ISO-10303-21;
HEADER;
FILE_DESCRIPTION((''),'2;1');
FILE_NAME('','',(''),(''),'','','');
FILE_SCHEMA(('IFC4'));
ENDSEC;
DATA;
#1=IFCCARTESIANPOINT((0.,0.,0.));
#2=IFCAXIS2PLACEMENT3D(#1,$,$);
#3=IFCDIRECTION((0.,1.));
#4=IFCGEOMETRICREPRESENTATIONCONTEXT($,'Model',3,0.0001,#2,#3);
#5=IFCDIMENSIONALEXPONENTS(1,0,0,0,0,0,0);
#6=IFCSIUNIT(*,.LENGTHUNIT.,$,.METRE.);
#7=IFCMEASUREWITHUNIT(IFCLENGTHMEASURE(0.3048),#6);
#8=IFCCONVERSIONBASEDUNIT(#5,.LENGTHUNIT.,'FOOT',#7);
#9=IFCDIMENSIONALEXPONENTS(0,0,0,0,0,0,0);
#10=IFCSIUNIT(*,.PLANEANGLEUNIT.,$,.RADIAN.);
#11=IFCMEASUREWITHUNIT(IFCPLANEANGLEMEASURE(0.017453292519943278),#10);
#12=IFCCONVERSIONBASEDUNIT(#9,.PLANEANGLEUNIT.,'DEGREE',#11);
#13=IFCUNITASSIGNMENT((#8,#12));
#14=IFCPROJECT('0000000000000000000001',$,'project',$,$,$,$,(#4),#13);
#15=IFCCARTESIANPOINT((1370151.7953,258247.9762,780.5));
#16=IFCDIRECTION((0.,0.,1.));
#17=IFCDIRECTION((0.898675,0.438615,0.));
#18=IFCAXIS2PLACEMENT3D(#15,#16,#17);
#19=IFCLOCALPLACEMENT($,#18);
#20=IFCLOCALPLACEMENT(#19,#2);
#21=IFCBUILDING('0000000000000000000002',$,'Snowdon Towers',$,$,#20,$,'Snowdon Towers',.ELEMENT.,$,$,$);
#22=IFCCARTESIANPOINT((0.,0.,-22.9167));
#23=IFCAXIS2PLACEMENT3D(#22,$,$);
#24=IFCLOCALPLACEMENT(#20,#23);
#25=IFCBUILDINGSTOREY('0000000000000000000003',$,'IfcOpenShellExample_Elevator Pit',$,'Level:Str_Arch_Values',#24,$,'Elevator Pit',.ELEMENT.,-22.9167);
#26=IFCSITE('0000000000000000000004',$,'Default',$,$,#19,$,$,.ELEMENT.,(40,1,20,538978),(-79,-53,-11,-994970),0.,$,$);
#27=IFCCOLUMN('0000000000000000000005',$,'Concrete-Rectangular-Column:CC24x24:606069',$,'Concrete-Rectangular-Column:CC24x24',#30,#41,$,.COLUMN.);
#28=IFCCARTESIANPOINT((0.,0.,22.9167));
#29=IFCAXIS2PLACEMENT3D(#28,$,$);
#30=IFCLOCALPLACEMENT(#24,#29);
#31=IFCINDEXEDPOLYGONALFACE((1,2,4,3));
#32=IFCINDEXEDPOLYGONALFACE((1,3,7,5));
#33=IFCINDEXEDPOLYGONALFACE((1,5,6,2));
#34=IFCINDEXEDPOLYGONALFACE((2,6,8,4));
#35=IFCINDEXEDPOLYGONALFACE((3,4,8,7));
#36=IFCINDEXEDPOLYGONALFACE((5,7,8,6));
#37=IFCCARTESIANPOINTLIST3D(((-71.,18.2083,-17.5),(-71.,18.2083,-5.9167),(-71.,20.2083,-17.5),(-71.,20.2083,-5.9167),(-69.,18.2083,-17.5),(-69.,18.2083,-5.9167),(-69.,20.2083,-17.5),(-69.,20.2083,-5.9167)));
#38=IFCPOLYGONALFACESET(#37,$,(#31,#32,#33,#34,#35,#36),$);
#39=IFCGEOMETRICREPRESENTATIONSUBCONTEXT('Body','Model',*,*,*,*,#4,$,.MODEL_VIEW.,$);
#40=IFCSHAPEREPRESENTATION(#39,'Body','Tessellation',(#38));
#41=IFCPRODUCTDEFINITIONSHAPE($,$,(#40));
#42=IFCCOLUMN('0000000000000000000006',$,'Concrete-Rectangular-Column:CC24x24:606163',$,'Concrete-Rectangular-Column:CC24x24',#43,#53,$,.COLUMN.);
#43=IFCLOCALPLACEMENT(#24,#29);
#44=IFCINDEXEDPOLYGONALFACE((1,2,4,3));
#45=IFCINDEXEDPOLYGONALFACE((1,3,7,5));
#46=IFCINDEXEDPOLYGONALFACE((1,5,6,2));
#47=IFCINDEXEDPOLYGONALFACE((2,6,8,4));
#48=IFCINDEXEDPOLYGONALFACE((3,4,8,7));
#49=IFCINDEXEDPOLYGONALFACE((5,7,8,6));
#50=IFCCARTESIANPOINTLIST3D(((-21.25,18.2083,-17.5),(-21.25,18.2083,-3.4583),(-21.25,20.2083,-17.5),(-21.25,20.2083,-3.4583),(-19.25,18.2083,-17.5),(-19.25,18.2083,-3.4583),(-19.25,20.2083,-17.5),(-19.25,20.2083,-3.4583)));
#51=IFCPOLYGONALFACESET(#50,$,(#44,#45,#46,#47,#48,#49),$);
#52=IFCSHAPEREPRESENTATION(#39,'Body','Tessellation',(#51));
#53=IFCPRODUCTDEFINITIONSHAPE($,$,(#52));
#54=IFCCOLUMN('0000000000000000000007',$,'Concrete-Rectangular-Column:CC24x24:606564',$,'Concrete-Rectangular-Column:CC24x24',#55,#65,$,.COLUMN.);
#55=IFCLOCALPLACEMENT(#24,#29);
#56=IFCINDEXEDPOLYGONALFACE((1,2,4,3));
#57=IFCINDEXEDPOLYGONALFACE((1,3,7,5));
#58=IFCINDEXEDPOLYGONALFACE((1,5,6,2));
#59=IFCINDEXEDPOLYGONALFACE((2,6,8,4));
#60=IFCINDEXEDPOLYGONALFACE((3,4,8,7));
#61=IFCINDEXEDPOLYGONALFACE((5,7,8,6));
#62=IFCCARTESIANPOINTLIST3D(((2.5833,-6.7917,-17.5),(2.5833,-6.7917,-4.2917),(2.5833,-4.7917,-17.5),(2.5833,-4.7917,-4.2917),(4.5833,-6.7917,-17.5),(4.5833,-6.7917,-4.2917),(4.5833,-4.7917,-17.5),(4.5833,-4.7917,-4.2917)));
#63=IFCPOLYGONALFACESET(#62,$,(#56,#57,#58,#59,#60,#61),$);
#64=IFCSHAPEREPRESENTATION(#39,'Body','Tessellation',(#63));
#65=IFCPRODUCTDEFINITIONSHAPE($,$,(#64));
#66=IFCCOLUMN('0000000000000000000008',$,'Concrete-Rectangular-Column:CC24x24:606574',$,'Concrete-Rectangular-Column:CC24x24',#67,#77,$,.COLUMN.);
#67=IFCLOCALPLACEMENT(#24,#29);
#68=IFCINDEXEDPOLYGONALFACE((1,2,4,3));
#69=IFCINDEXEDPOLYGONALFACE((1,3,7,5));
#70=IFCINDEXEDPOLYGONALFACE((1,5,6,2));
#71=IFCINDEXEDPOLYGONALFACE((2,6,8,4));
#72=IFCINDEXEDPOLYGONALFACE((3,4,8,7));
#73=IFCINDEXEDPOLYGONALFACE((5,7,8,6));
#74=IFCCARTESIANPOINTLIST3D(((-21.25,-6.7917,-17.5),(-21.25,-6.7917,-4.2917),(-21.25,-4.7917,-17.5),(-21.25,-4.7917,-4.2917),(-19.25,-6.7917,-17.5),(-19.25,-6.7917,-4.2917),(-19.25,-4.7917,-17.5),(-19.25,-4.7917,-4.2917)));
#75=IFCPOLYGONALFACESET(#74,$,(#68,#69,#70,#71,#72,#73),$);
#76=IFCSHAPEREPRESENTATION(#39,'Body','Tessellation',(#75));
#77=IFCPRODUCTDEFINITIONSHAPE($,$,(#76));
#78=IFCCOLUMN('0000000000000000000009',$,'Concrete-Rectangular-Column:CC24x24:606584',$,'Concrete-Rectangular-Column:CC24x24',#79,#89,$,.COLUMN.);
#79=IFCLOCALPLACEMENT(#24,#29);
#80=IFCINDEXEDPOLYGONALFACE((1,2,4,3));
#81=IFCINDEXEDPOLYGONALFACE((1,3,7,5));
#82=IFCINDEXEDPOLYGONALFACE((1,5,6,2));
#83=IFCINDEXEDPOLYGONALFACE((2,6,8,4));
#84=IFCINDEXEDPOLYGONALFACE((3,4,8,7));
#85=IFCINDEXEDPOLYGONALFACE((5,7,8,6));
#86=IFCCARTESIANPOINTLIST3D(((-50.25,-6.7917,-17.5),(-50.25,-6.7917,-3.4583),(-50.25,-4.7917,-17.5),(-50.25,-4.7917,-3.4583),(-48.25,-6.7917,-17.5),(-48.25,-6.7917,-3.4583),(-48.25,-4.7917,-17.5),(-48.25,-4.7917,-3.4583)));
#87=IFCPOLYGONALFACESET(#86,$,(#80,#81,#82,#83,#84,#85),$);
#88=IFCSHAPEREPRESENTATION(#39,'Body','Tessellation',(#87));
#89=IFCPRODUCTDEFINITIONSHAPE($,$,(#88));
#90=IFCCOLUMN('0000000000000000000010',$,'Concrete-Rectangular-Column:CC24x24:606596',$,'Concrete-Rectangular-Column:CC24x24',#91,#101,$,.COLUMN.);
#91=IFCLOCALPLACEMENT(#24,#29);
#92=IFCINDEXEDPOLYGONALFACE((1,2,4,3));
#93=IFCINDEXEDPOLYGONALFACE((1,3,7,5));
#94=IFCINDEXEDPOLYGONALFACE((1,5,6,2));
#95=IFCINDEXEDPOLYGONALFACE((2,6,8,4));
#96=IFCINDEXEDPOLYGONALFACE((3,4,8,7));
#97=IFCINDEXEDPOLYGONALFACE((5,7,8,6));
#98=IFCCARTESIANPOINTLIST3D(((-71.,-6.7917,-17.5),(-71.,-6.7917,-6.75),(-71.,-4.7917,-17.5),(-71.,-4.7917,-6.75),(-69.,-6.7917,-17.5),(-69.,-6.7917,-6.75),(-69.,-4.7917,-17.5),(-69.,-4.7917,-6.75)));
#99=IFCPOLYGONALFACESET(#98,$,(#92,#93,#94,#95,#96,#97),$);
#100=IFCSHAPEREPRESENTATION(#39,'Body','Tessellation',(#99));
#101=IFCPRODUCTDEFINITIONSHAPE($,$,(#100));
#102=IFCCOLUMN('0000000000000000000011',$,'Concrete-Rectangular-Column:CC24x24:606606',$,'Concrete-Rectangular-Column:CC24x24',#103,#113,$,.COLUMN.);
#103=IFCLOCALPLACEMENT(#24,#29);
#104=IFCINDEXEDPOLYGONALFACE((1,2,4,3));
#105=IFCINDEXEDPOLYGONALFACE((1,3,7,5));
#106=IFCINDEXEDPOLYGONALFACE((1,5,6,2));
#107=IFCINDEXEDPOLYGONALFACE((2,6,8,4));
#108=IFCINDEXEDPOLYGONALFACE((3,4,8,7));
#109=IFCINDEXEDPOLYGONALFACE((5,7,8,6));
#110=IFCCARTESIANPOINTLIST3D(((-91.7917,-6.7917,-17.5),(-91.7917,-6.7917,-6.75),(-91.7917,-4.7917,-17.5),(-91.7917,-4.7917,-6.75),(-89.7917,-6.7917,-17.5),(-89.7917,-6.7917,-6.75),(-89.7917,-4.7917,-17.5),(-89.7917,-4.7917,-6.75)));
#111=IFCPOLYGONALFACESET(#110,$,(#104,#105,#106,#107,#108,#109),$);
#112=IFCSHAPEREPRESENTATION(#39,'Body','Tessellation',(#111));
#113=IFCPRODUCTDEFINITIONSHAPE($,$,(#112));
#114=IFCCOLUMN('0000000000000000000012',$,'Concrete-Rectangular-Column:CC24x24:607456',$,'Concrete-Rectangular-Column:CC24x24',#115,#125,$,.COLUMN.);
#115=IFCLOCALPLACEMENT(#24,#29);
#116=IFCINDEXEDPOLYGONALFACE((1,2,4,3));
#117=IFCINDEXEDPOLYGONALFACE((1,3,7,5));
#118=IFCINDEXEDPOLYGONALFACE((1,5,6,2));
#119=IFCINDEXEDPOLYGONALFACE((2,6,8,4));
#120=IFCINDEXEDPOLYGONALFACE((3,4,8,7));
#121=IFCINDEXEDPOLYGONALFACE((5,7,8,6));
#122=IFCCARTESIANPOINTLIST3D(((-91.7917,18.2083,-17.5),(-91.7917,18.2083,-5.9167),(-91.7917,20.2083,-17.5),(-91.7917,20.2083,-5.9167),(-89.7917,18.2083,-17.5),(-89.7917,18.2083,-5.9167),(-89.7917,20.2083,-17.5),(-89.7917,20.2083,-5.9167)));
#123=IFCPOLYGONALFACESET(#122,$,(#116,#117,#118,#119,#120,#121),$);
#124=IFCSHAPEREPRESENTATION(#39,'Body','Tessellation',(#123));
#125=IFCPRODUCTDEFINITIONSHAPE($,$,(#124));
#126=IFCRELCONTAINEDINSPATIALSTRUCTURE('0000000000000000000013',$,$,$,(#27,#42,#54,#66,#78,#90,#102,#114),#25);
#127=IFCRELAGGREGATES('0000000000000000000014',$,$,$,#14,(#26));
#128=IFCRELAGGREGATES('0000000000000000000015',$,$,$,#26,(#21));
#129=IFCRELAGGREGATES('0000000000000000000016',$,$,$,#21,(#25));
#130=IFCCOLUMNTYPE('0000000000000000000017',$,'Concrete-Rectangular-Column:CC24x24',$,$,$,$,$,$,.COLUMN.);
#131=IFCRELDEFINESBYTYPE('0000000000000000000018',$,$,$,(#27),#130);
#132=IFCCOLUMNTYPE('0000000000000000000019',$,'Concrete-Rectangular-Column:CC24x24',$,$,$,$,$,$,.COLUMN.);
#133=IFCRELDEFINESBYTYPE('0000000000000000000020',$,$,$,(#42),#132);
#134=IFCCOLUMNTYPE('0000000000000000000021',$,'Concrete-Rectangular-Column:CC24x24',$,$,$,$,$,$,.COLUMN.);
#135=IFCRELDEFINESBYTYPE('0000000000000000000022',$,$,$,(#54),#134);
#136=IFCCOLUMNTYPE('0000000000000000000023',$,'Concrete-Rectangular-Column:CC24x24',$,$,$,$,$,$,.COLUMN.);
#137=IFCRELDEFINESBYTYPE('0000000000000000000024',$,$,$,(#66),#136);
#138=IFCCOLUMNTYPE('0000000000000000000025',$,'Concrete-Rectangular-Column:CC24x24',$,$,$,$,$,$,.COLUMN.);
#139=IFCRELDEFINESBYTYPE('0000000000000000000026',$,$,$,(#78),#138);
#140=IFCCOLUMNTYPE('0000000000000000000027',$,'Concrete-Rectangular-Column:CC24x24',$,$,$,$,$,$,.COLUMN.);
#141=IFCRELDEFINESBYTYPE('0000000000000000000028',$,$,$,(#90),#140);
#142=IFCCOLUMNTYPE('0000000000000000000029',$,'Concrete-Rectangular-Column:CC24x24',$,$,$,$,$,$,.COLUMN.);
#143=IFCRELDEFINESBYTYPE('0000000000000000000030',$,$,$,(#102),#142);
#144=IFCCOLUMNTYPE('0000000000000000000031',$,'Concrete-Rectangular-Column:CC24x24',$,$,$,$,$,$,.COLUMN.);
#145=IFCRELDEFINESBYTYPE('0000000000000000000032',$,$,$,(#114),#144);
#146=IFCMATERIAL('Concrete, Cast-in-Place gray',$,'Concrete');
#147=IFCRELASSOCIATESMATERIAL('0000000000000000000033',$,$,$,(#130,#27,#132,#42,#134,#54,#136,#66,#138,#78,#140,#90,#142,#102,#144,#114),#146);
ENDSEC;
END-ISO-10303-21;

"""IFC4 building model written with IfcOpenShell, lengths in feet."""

from ifc_helpers import new_model, entity, si_unit, converted_unit, direction, frame, origin, place, context, subcontext, project, spatial, indexed_curve, outline, extrude, source, transform, mapped, material, type_object, type_shapes, element, save


model = new_model("IFC4")

# Units and contexts
model_context = context("Model", 3, precision=0.0001, world=origin(), true_north=direction((0.0, 1.0)))
body_context = subcontext(model_context, "Body", "Model", "MODEL_VIEW")
ifc_project = project(units=[converted_unit("LENGTHUNIT", "FOOT", entity("IfcLengthMeasure", 0.3048), si_unit("LENGTHUNIT", "METRE"), dimensions=[1, 0, 0, 0, 0, 0, 0]), converted_unit("PLANEANGLEUNIT", "DEGREE", entity("IfcPlaneAngleMeasure", 0.017453292519943278), si_unit("PLANEANGLEUNIT", "RADIAN"), dimensions=[0, 0, 0, 0, 0, 0, 0])], contexts=[model_context])

# Site, building, storey
site_placement = place(None, frame((1370151.7953, 258247.9762, 780.5), z_axis=(0.0, 0.0, 1.0), x_axis=(0.898675, 0.438615, 0.0)))
site = spatial("IfcSite", under=ifc_project, at=site_placement, Name="Default", CompositionType="ELEMENT", RefLatitude=(40, 1, 20, 538978), RefLongitude=(-79, -53, -11, -994970), RefElevation=0.0)
building_placement = place(site_placement, origin())
building = spatial("IfcBuilding", under=site, at=building_placement, Name="Snowdon Towers", LongName="Snowdon Towers", CompositionType="ELEMENT")
storey_placement = place(building_placement, frame((0.0, 0.0, -22.9167)))
storey = spatial("IfcBuildingStorey", under=building, at=storey_placement, Name="IfcOpenShellExample_Elevator Pit", ObjectType="Level:Str_Arch_Values", LongName="Elevator Pit", CompositionType="ELEMENT", Elevation=-22.9167)

# Shared definitions
ifc_material = material(Name="Concrete, Cast-in-Place gray", Category="Concrete")

# Columns
column_type_1 = type_object("IfcColumnType", Name="Concrete-Rectangular-Column:CC24x24", PredefinedType="COLUMN", material=ifc_material)
shared_shape_1 = source(origin(), body_context, "Body", "SweptSolid", [
    extrude(outline(indexed_curve([(-1.0, -1.0), (1.0, -1.0), (1.0, 1.0), (-1.0, 1.0), (-1.0, -1.0)], self_intersect=False)), frame((-70.0, 19.2083, -17.5), z_axis=(0.0, 0.0, 1.0), x_axis=(-1.0, 0.0, 0.0)), (0.0, 0.0, 1.0), 11.5833),
])
type_shapes(column_type_1, [shared_shape_1])
column_1_placement = place(storey_placement, frame((0.0, 0.0, 22.9167)))
element("IfcColumn", 1, at=column_1_placement, inside=storey, type_object=column_type_1, material=ifc_material, Name="Concrete-Rectangular-Column:CC24x24:606069", ObjectType="Concrete-Rectangular-Column:CC24x24", PredefinedType="COLUMN", context=body_context, shape_type="MappedRepresentation", body=[
    mapped(shared_shape_1, transform((0.0, 0.0, 0.0), scale=1.0)),
])
column_type_2 = type_object("IfcColumnType", Name="Concrete-Rectangular-Column:CC24x24", PredefinedType="COLUMN", material=ifc_material)
shared_shape_2 = source(origin(), body_context, "Body", "SweptSolid", [
    extrude(outline(indexed_curve([(-1.0, -1.0), (1.0, -1.0), (1.0, 1.0), (-1.0, 1.0), (-1.0, -1.0)], self_intersect=False)), frame((-20.25, 19.2083, -17.5), z_axis=(0.0, 0.0, 1.0), x_axis=(-1.0, 0.0, 0.0)), (0.0, 0.0, 1.0), 14.0417),
])
type_shapes(column_type_2, [shared_shape_2])
column_2_placement = place(storey_placement, frame((0.0, 0.0, 22.9167)))
element("IfcColumn", 2, at=column_2_placement, inside=storey, type_object=column_type_2, material=ifc_material, Name="Concrete-Rectangular-Column:CC24x24:606163", ObjectType="Concrete-Rectangular-Column:CC24x24", PredefinedType="COLUMN", context=body_context, shape_type="MappedRepresentation", body=[
    mapped(shared_shape_2, transform((0.0, 0.0, 0.0), scale=1.0)),
])
column_type_3 = type_object("IfcColumnType", Name="Concrete-Rectangular-Column:CC24x24", PredefinedType="COLUMN", material=ifc_material)
shared_shape_3 = source(origin(), body_context, "Body", "SweptSolid", [
    extrude(outline(indexed_curve([(-1.0, -1.0), (1.0, -1.0), (1.0, 1.0), (-1.0, 1.0), (-1.0, -1.0)], self_intersect=False)), frame((3.5833, -5.7917, -17.5), z_axis=(0.0, 0.0, 1.0), x_axis=(-1.0, 0.0, 0.0)), (0.0, 0.0, 1.0), 13.2083),
])
type_shapes(column_type_3, [shared_shape_3])
column_3_placement = place(storey_placement, frame((0.0, 0.0, 22.9167)))
element("IfcColumn", 3, at=column_3_placement, inside=storey, type_object=column_type_3, material=ifc_material, Name="Concrete-Rectangular-Column:CC24x24:606564", ObjectType="Concrete-Rectangular-Column:CC24x24", PredefinedType="COLUMN", context=body_context, shape_type="MappedRepresentation", body=[
    mapped(shared_shape_3, transform((0.0, 0.0, 0.0), scale=1.0)),
])
column_type_4 = type_object("IfcColumnType", Name="Concrete-Rectangular-Column:CC24x24", PredefinedType="COLUMN", material=ifc_material)
shared_shape_4 = source(origin(), body_context, "Body", "SweptSolid", [
    extrude(outline(indexed_curve([(-1.0, -1.0), (1.0, -1.0), (1.0, 1.0), (-1.0, 1.0), (-1.0, -1.0)], self_intersect=False)), frame((-20.25, -5.7917, -17.5), z_axis=(0.0, 0.0, 1.0), x_axis=(-1.0, 0.0, 0.0)), (0.0, 0.0, 1.0), 13.2083),
])
type_shapes(column_type_4, [shared_shape_4])
column_4_placement = place(storey_placement, frame((0.0, 0.0, 22.9167)))
element("IfcColumn", 4, at=column_4_placement, inside=storey, type_object=column_type_4, material=ifc_material, Name="Concrete-Rectangular-Column:CC24x24:606574", ObjectType="Concrete-Rectangular-Column:CC24x24", PredefinedType="COLUMN", context=body_context, shape_type="MappedRepresentation", body=[
    mapped(shared_shape_4, transform((0.0, 0.0, 0.0), scale=1.0)),
])
column_type_5 = type_object("IfcColumnType", Name="Concrete-Rectangular-Column:CC24x24", PredefinedType="COLUMN", material=ifc_material)
shared_shape_5 = source(origin(), body_context, "Body", "SweptSolid", [
    extrude(outline(indexed_curve([(-1.0, -1.0), (1.0, -1.0), (1.0, 1.0), (-1.0, 1.0), (-1.0, -1.0)], self_intersect=False)), frame((-49.25, -5.7917, -17.5), z_axis=(0.0, 0.0, 1.0), x_axis=(-1.0, 0.0, 0.0)), (0.0, 0.0, 1.0), 14.0417),
])
type_shapes(column_type_5, [shared_shape_5])
column_5_placement = place(storey_placement, frame((0.0, 0.0, 22.9167)))
element("IfcColumn", 5, at=column_5_placement, inside=storey, type_object=column_type_5, material=ifc_material, Name="Concrete-Rectangular-Column:CC24x24:606584", ObjectType="Concrete-Rectangular-Column:CC24x24", PredefinedType="COLUMN", context=body_context, shape_type="MappedRepresentation", body=[
    mapped(shared_shape_5, transform((0.0, 0.0, 0.0), scale=1.0)),
])
column_type_6 = type_object("IfcColumnType", Name="Concrete-Rectangular-Column:CC24x24", PredefinedType="COLUMN", material=ifc_material)
shared_shape_6 = source(origin(), body_context, "Body", "SweptSolid", [
    extrude(outline(indexed_curve([(-1.0, -1.0), (1.0, -1.0), (1.0, 1.0), (-1.0, 1.0), (-1.0, -1.0)], self_intersect=False)), frame((-70.0, -5.7917, -17.5), z_axis=(0.0, 0.0, 1.0), x_axis=(-1.0, 0.0, 0.0)), (0.0, 0.0, 1.0), 10.75),
])
type_shapes(column_type_6, [shared_shape_6])
column_6_placement = place(storey_placement, frame((0.0, 0.0, 22.9167)))
element("IfcColumn", 6, at=column_6_placement, inside=storey, type_object=column_type_6, material=ifc_material, Name="Concrete-Rectangular-Column:CC24x24:606596", ObjectType="Concrete-Rectangular-Column:CC24x24", PredefinedType="COLUMN", context=body_context, shape_type="MappedRepresentation", body=[
    mapped(shared_shape_6, transform((0.0, 0.0, 0.0), scale=1.0)),
])
column_type_7 = type_object("IfcColumnType", Name="Concrete-Rectangular-Column:CC24x24", PredefinedType="COLUMN", material=ifc_material)
shared_shape_7 = source(origin(), body_context, "Body", "SweptSolid", [
    extrude(outline(indexed_curve([(-1.0, -1.0), (1.0, -1.0), (1.0, 1.0), (-1.0, 1.0), (-1.0, -1.0)], self_intersect=False)), frame((-90.7917, -5.7917, -17.5), z_axis=(0.0, 0.0, 1.0), x_axis=(-1.0, 0.0, 0.0)), (0.0, 0.0, 1.0), 10.75),
])
type_shapes(column_type_7, [shared_shape_7])
column_7_placement = place(storey_placement, frame((0.0, 0.0, 22.9167)))
element("IfcColumn", 7, at=column_7_placement, inside=storey, type_object=column_type_7, material=ifc_material, Name="Concrete-Rectangular-Column:CC24x24:606606", ObjectType="Concrete-Rectangular-Column:CC24x24", PredefinedType="COLUMN", context=body_context, shape_type="MappedRepresentation", body=[
    mapped(shared_shape_7, transform((0.0, 0.0, 0.0), scale=1.0)),
])
column_type_8 = type_object("IfcColumnType", Name="Concrete-Rectangular-Column:CC24x24", PredefinedType="COLUMN", material=ifc_material)
shared_shape_8 = source(origin(), body_context, "Body", "SweptSolid", [
    extrude(outline(indexed_curve([(-1.0, -1.0), (1.0, -1.0), (1.0, 1.0), (-1.0, 1.0), (-1.0, -1.0)], self_intersect=False)), frame((-90.7917, 19.2083, -17.5), z_axis=(0.0, 0.0, 1.0), x_axis=(-1.0, 0.0, 0.0)), (0.0, 0.0, 1.0), 11.5833),
])
type_shapes(column_type_8, [shared_shape_8])
column_8_placement = place(storey_placement, frame((0.0, 0.0, 22.9167)))
element("IfcColumn", 8, at=column_8_placement, inside=storey, type_object=column_type_8, material=ifc_material, Name="Concrete-Rectangular-Column:CC24x24:607456", ObjectType="Concrete-Rectangular-Column:CC24x24", PredefinedType="COLUMN", context=body_context, shape_type="MappedRepresentation", body=[
    mapped(shared_shape_8, transform((0.0, 0.0, 0.0), scale=1.0)),
])

save(model, "model.ifc")
